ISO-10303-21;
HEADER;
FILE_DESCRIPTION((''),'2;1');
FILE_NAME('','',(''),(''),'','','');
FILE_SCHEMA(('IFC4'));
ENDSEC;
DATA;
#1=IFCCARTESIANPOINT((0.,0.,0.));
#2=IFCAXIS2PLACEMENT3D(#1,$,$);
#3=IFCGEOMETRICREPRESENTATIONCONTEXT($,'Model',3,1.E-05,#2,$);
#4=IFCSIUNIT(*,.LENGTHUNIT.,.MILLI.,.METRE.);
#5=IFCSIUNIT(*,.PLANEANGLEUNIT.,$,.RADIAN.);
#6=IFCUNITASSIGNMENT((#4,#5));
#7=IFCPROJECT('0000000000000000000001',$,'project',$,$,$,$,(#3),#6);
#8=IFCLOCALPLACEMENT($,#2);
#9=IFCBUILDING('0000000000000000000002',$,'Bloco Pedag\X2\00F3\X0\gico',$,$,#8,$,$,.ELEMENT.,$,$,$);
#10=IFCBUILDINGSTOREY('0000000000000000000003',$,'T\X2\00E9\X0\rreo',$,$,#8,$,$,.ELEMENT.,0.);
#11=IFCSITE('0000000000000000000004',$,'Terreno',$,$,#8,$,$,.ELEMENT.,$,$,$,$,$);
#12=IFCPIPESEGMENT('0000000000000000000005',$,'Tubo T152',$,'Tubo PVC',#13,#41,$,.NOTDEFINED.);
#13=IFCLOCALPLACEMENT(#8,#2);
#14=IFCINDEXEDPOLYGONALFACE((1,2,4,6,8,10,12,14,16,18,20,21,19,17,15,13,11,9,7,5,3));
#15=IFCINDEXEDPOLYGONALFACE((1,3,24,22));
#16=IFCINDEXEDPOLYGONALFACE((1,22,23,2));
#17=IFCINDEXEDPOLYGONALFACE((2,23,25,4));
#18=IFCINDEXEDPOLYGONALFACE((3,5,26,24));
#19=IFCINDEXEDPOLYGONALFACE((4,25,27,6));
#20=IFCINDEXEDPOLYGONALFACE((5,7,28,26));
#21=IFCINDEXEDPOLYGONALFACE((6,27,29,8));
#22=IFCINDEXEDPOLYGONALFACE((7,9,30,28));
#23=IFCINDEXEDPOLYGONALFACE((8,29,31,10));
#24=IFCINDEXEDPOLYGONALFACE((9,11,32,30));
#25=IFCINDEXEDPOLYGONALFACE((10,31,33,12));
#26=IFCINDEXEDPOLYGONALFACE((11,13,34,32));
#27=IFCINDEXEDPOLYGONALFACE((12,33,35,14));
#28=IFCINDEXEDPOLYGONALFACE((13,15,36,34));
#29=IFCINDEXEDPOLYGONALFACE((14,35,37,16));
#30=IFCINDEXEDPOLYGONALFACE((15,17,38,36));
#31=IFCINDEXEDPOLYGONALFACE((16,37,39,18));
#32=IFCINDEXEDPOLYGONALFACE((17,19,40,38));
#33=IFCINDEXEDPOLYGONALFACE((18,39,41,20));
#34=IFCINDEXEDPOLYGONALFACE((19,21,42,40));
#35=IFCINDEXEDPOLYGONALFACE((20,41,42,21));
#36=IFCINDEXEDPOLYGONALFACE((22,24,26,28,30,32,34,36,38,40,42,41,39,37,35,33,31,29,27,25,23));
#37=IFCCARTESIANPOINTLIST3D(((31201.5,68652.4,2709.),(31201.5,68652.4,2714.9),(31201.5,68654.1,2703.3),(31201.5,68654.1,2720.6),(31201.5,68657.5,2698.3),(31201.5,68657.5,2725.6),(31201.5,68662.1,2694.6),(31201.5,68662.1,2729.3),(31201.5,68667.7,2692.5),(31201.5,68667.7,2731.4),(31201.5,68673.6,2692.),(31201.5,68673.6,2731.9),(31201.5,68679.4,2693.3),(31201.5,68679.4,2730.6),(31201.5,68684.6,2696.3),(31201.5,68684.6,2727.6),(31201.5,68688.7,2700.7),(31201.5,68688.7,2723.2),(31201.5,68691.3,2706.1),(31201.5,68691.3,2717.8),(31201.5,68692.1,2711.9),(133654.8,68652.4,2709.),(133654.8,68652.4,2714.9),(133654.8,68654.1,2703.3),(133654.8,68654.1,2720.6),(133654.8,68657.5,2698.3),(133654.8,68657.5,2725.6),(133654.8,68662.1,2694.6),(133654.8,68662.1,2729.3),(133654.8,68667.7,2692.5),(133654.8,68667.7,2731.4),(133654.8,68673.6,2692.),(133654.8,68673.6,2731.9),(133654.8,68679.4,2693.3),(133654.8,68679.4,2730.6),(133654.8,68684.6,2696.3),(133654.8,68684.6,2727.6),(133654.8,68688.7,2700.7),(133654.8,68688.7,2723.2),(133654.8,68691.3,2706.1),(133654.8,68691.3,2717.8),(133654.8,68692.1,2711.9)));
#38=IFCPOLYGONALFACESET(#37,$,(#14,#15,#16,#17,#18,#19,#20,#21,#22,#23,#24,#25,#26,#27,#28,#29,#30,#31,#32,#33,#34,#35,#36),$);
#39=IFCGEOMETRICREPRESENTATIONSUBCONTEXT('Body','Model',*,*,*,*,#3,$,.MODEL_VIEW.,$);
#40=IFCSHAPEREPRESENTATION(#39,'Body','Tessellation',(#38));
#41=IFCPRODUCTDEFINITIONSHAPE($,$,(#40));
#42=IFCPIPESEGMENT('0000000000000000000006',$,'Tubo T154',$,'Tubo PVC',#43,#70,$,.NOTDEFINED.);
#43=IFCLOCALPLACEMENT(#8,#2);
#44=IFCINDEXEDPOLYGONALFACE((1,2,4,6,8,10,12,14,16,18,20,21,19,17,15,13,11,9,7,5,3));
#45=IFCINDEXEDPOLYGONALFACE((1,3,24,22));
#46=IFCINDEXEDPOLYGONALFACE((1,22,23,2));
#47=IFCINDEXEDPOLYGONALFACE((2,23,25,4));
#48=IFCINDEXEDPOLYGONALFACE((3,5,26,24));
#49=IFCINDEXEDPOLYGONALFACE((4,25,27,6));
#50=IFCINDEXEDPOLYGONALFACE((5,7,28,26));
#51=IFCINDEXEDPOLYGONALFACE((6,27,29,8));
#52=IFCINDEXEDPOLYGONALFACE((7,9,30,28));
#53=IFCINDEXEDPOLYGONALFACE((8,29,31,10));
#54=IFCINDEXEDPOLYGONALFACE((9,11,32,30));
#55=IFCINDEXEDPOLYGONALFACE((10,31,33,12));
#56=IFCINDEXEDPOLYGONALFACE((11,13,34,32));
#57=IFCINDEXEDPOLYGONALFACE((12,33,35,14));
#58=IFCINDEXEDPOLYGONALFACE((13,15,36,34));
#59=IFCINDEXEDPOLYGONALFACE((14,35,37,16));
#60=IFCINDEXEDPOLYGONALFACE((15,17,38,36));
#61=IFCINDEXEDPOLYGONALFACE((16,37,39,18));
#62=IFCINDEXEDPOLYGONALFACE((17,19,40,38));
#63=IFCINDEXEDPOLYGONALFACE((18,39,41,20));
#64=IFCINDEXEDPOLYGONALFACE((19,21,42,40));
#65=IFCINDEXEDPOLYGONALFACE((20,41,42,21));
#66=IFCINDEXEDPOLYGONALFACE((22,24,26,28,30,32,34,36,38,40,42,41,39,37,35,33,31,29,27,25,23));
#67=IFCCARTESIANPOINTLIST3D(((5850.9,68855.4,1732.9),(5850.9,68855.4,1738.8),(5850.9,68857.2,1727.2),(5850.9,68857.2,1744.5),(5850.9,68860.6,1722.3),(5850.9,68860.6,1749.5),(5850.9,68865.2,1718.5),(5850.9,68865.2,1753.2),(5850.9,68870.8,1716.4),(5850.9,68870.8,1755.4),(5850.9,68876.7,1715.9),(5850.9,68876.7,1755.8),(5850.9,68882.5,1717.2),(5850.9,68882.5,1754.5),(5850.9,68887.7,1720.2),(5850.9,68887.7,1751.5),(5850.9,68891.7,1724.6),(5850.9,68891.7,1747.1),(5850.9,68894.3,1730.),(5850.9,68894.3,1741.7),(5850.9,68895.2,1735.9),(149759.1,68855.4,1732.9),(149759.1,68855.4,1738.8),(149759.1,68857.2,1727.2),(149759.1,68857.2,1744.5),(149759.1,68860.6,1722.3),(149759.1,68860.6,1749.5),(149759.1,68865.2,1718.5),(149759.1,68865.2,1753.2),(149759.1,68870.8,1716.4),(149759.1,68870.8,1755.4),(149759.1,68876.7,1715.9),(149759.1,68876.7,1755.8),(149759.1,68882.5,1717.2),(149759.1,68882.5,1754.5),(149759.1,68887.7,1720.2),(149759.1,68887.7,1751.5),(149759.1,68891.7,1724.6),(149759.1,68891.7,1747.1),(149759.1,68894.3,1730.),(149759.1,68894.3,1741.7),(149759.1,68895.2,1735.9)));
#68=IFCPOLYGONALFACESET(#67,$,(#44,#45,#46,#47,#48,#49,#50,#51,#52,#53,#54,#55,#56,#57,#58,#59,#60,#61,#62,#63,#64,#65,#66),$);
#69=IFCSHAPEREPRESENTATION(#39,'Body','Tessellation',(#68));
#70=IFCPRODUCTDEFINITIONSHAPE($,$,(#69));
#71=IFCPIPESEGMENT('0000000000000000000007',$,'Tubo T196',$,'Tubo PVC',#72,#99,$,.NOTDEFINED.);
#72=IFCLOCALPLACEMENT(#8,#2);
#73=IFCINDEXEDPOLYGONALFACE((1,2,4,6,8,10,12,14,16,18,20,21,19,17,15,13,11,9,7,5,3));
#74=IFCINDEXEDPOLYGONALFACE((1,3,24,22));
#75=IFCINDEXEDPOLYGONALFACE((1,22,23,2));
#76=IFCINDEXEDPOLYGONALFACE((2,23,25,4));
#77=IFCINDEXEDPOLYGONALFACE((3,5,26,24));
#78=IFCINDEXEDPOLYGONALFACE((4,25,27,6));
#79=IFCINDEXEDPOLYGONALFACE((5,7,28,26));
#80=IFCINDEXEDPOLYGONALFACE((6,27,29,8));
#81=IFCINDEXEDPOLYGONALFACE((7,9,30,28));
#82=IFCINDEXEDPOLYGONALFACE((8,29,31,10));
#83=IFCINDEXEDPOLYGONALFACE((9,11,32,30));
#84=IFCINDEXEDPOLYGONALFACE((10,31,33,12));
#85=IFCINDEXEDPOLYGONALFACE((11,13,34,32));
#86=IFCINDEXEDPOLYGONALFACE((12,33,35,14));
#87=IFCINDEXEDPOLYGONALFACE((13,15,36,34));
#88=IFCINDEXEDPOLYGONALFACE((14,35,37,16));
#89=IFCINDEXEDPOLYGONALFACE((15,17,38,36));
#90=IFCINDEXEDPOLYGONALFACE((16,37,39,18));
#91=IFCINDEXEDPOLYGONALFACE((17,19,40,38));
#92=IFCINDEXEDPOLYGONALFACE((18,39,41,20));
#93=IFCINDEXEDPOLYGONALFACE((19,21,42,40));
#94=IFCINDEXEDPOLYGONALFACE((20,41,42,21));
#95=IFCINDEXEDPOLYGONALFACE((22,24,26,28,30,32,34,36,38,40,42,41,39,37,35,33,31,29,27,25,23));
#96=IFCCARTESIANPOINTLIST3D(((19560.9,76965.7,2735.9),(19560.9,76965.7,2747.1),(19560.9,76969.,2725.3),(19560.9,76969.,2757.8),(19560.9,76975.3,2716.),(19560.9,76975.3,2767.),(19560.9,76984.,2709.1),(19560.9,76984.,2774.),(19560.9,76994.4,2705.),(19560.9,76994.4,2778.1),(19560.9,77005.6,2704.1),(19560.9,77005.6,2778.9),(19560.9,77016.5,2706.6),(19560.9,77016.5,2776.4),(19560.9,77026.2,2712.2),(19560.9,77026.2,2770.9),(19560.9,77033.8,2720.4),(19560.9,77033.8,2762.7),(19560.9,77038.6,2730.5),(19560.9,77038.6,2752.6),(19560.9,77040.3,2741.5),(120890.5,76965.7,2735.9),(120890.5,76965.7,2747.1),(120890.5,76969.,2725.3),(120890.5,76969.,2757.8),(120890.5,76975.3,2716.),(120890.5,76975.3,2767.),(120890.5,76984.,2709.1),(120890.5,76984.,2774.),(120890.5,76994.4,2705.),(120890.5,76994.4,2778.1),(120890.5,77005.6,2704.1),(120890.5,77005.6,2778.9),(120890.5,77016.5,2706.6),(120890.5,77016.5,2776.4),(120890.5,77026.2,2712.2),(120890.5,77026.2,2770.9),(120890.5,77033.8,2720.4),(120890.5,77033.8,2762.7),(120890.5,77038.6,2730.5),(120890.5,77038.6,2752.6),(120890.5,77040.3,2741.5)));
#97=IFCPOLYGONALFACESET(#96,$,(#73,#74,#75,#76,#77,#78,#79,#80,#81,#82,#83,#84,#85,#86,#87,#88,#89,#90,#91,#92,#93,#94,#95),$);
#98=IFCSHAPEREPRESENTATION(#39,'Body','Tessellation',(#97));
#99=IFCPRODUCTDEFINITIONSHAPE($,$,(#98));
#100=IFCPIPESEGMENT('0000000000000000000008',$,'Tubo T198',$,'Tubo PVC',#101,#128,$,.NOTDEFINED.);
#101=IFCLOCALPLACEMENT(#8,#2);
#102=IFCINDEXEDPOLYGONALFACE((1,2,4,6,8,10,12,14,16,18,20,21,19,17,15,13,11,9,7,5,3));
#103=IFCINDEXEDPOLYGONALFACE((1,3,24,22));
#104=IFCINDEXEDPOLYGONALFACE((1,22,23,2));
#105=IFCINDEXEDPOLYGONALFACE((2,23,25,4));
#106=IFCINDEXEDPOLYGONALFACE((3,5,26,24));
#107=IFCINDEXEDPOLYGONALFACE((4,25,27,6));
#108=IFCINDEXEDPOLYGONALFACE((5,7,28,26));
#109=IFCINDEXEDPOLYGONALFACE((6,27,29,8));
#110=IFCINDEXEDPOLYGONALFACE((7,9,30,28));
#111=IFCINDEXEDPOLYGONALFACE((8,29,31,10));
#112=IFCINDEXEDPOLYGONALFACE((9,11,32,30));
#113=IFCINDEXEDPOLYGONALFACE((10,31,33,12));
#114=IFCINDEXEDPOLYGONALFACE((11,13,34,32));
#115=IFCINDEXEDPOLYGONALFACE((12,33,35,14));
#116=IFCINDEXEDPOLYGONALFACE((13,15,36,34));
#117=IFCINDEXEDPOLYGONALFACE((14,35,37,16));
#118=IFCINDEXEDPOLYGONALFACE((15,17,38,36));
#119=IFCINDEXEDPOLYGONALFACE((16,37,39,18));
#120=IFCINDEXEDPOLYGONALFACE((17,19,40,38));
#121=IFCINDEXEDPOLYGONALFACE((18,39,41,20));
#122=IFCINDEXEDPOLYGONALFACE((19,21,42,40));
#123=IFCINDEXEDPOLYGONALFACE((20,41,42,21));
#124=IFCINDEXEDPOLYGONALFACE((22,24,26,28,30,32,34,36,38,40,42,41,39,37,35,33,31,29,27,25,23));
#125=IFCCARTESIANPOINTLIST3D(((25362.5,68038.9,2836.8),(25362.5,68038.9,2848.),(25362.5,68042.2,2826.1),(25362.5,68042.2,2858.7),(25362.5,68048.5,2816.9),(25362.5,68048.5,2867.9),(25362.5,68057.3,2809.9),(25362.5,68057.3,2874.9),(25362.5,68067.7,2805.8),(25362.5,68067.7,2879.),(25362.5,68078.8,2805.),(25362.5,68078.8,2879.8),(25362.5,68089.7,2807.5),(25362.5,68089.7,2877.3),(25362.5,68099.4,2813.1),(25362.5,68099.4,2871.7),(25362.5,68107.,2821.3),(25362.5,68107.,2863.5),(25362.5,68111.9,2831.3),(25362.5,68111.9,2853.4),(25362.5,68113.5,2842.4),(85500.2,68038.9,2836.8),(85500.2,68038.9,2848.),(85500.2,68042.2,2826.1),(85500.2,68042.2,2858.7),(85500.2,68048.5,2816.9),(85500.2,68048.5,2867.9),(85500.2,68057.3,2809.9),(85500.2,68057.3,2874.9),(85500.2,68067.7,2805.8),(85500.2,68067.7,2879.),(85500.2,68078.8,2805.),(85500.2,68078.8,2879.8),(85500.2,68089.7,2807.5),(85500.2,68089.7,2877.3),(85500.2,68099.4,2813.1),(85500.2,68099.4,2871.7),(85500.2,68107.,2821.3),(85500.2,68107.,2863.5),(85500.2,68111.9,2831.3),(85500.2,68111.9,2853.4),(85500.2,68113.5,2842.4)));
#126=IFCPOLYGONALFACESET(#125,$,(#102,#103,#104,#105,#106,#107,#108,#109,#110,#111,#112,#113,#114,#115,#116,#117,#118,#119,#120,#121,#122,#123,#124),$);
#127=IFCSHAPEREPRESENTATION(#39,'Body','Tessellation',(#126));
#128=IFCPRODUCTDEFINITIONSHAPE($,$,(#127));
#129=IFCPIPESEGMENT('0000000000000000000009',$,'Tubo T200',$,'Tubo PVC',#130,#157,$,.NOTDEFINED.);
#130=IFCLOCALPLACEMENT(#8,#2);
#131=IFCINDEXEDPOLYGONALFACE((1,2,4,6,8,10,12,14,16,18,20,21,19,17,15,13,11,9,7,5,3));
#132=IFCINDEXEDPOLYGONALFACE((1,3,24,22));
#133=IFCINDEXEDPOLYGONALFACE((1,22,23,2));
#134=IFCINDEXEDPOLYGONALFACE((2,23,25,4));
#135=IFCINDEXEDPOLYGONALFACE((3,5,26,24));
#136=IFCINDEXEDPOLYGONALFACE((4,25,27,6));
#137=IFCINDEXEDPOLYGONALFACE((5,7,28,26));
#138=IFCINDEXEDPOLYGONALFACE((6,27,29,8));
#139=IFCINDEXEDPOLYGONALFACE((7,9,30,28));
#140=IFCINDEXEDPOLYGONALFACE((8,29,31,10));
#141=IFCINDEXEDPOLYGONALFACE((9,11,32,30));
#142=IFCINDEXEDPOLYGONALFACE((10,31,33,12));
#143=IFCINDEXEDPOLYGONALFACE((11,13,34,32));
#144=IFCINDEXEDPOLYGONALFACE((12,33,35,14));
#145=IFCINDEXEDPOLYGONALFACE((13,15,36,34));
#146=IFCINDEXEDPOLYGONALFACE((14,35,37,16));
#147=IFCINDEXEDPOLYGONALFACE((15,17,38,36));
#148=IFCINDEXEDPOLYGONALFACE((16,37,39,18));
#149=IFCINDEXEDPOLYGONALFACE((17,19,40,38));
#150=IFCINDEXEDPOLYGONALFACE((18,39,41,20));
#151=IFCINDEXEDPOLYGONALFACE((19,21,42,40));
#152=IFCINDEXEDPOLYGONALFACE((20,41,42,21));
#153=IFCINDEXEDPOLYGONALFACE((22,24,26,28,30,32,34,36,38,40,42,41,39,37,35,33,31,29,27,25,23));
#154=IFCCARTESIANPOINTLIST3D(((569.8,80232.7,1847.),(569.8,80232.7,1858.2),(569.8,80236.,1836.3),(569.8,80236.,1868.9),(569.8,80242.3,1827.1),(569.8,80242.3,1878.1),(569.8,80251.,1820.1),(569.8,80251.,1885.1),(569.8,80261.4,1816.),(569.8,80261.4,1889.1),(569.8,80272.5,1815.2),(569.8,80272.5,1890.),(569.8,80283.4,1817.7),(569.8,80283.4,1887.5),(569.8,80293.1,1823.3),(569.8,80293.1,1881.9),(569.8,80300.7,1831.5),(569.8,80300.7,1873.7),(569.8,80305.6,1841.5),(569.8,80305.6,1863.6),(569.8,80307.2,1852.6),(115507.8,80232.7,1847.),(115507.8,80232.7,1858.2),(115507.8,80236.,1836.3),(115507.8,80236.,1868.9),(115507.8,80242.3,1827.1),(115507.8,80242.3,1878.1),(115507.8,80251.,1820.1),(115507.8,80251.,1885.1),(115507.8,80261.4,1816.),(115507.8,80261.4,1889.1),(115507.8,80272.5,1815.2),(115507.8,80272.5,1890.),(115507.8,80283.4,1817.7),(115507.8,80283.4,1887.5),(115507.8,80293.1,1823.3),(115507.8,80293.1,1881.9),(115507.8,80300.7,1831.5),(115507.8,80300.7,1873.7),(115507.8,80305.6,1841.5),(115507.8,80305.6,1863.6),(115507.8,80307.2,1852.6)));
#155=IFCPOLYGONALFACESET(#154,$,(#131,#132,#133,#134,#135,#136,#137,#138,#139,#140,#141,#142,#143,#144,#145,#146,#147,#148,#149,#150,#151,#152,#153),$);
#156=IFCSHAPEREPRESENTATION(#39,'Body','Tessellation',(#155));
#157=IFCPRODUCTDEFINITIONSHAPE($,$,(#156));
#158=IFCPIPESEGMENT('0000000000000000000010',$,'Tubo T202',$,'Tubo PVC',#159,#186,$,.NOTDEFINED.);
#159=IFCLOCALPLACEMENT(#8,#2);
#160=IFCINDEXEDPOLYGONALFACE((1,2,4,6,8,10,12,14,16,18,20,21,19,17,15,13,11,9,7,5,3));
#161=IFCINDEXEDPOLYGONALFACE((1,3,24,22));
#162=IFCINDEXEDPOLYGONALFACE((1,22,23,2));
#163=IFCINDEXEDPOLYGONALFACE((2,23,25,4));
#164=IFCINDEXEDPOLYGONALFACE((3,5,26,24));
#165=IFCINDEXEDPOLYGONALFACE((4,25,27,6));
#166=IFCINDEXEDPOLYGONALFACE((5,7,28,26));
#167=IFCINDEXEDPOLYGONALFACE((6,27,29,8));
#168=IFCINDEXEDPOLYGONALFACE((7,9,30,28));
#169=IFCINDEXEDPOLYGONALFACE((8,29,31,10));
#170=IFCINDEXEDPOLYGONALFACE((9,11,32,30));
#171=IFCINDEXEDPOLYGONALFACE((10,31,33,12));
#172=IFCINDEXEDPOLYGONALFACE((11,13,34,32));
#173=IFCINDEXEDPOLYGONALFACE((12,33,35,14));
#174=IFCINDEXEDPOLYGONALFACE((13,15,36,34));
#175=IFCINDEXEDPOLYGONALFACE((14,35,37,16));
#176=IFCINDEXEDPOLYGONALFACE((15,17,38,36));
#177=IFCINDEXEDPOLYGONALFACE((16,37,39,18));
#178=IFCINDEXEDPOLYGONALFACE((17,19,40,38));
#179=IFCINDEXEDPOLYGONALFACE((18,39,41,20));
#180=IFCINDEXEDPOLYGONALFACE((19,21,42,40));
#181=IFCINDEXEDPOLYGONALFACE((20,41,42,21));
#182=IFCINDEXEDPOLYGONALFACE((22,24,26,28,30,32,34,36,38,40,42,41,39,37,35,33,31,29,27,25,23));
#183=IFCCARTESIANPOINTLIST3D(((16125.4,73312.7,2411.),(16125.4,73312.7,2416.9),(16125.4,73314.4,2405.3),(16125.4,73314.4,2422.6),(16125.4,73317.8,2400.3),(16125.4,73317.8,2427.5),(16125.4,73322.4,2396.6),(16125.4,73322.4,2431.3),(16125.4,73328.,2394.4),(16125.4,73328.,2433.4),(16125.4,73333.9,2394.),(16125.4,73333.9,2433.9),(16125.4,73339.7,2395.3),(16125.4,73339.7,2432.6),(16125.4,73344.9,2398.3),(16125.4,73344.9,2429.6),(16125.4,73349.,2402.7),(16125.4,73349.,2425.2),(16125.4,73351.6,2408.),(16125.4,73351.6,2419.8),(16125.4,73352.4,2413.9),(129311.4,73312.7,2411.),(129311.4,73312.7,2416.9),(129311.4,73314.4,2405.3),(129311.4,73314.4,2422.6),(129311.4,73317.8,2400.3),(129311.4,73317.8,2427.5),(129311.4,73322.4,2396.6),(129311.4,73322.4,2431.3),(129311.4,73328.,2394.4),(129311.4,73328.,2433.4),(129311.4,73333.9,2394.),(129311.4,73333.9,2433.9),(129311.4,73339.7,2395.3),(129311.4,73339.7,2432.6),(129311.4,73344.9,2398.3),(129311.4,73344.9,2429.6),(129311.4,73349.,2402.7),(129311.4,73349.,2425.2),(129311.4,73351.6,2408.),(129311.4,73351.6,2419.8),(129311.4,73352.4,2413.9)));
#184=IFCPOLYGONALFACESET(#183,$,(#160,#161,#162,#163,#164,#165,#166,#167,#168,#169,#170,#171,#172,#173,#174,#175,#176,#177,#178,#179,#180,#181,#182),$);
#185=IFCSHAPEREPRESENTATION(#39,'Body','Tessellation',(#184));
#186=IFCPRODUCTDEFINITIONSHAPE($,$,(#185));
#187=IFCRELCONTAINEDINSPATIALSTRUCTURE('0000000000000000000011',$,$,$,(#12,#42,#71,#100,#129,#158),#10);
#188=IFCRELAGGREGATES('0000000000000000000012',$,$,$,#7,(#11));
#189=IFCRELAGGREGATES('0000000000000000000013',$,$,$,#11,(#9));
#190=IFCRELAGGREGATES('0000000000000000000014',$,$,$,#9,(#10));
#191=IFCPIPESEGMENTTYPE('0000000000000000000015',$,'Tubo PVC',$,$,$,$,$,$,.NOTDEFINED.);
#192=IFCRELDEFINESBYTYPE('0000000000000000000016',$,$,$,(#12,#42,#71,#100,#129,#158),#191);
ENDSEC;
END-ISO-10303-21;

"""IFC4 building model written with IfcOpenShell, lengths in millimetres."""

from ifc_helpers import new_model, si_unit, frame, origin, origin_2d, place, context, subcontext, project, spatial, circle, extrude, type_object, element, save


model = new_model("IFC4")

# Units and contexts
model_context = context("Model", 3, precision=1e-05, world=origin())
body_context = subcontext(model_context, "Body", "Model", "MODEL_VIEW")
ifc_project = project(units=[si_unit("LENGTHUNIT", "METRE", prefix="MILLI"), si_unit("PLANEANGLEUNIT", "RADIAN")], contexts=[model_context])

# Site, building, storey
placement = place(None, origin())
site = spatial("IfcSite", under=ifc_project, at=placement, Name="Terreno", CompositionType="ELEMENT")
building = spatial("IfcBuilding", under=site, at=placement, Name="Bloco Pedagógico", CompositionType="ELEMENT")
storey = spatial("IfcBuildingStorey", under=building, at=placement, Name="Térreo", CompositionType="ELEMENT", Elevation=0.0)

# Pipe segments
pipe_segment_type = type_object("IfcPipeSegmentType", Name="Tubo PVC", PredefinedType="NOTDEFINED")
pipe_segment_1_placement = place(None, frame((31201.5, 68672.1, 2711.9), z_axis=(1.0, 0.0, 0.0), x_axis=(0.0, 1.0, 0.0)))
element("IfcPipeSegment", 1, at=pipe_segment_1_placement, inside=storey, type_object=pipe_segment_type, Name="Tubo T152", ObjectType="Tubo PVC", PredefinedType="NOTDEFINED", context=body_context, shape_type="SweptSolid", body=[
    extrude(circle(Radius=20.0, at=origin_2d()), None, (0.0, 0.0, 1.0), 102453.3),
])
pipe_segment_2_placement = place(None, frame((5850.9, 68875.2, 1735.9), z_axis=(1.0, 0.0, 0.0), x_axis=(0.0, 1.0, 0.0)))
element("IfcPipeSegment", 2, at=pipe_segment_2_placement, inside=storey, type_object=pipe_segment_type, Name="Tubo T154", ObjectType="Tubo PVC", PredefinedType="NOTDEFINED", context=body_context, shape_type="SweptSolid", body=[
    extrude(circle(Radius=20.0, at=origin_2d()), None, (0.0, 0.0, 1.0), 143908.3),
])
pipe_segment_3_placement = place(None, frame((19560.9, 77002.8, 2741.5), z_axis=(1.0, 0.0, 0.0), x_axis=(0.0, 1.0, 0.0)))
element("IfcPipeSegment", 3, at=pipe_segment_3_placement, inside=storey, type_object=pipe_segment_type, Name="Tubo T196", ObjectType="Tubo PVC", PredefinedType="NOTDEFINED", context=body_context, shape_type="SweptSolid", body=[
    extrude(circle(Radius=37.5, at=origin_2d()), None, (0.0, 0.0, 1.0), 101329.6),
])
pipe_segment_4_placement = place(None, frame((25362.5, 68076.0, 2842.4), z_axis=(1.0, 0.0, 0.0), x_axis=(0.0, 1.0, 0.0)))
element("IfcPipeSegment", 4, at=pipe_segment_4_placement, inside=storey, type_object=pipe_segment_type, Name="Tubo T198", ObjectType="Tubo PVC", PredefinedType="NOTDEFINED", context=body_context, shape_type="SweptSolid", body=[
    extrude(circle(Radius=37.5, at=origin_2d()), None, (0.0, 0.0, 1.0), 60137.7),
])
pipe_segment_5_placement = place(None, frame((569.8, 80269.7, 1852.6), z_axis=(1.0, 0.0, 0.0), x_axis=(0.0, 1.0, 0.0)))
element("IfcPipeSegment", 5, at=pipe_segment_5_placement, inside=storey, type_object=pipe_segment_type, Name="Tubo T200", ObjectType="Tubo PVC", PredefinedType="NOTDEFINED", context=body_context, shape_type="SweptSolid", body=[
    extrude(circle(Radius=37.5, at=origin_2d()), None, (0.0, 0.0, 1.0), 114938.0),
])
pipe_segment_6_placement = place(None, frame((16125.4, 73332.4, 2413.9), z_axis=(1.0, 0.0, 0.0), x_axis=(0.0, 1.0, 0.0)))
element("IfcPipeSegment", 6, at=pipe_segment_6_placement, inside=storey, type_object=pipe_segment_type, Name="Tubo T202", ObjectType="Tubo PVC", PredefinedType="NOTDEFINED", context=body_context, shape_type="SweptSolid", body=[
    extrude(circle(Radius=20.0, at=origin_2d()), None, (0.0, 0.0, 1.0), 113186.0),
])

save(model, "model.ifc")
